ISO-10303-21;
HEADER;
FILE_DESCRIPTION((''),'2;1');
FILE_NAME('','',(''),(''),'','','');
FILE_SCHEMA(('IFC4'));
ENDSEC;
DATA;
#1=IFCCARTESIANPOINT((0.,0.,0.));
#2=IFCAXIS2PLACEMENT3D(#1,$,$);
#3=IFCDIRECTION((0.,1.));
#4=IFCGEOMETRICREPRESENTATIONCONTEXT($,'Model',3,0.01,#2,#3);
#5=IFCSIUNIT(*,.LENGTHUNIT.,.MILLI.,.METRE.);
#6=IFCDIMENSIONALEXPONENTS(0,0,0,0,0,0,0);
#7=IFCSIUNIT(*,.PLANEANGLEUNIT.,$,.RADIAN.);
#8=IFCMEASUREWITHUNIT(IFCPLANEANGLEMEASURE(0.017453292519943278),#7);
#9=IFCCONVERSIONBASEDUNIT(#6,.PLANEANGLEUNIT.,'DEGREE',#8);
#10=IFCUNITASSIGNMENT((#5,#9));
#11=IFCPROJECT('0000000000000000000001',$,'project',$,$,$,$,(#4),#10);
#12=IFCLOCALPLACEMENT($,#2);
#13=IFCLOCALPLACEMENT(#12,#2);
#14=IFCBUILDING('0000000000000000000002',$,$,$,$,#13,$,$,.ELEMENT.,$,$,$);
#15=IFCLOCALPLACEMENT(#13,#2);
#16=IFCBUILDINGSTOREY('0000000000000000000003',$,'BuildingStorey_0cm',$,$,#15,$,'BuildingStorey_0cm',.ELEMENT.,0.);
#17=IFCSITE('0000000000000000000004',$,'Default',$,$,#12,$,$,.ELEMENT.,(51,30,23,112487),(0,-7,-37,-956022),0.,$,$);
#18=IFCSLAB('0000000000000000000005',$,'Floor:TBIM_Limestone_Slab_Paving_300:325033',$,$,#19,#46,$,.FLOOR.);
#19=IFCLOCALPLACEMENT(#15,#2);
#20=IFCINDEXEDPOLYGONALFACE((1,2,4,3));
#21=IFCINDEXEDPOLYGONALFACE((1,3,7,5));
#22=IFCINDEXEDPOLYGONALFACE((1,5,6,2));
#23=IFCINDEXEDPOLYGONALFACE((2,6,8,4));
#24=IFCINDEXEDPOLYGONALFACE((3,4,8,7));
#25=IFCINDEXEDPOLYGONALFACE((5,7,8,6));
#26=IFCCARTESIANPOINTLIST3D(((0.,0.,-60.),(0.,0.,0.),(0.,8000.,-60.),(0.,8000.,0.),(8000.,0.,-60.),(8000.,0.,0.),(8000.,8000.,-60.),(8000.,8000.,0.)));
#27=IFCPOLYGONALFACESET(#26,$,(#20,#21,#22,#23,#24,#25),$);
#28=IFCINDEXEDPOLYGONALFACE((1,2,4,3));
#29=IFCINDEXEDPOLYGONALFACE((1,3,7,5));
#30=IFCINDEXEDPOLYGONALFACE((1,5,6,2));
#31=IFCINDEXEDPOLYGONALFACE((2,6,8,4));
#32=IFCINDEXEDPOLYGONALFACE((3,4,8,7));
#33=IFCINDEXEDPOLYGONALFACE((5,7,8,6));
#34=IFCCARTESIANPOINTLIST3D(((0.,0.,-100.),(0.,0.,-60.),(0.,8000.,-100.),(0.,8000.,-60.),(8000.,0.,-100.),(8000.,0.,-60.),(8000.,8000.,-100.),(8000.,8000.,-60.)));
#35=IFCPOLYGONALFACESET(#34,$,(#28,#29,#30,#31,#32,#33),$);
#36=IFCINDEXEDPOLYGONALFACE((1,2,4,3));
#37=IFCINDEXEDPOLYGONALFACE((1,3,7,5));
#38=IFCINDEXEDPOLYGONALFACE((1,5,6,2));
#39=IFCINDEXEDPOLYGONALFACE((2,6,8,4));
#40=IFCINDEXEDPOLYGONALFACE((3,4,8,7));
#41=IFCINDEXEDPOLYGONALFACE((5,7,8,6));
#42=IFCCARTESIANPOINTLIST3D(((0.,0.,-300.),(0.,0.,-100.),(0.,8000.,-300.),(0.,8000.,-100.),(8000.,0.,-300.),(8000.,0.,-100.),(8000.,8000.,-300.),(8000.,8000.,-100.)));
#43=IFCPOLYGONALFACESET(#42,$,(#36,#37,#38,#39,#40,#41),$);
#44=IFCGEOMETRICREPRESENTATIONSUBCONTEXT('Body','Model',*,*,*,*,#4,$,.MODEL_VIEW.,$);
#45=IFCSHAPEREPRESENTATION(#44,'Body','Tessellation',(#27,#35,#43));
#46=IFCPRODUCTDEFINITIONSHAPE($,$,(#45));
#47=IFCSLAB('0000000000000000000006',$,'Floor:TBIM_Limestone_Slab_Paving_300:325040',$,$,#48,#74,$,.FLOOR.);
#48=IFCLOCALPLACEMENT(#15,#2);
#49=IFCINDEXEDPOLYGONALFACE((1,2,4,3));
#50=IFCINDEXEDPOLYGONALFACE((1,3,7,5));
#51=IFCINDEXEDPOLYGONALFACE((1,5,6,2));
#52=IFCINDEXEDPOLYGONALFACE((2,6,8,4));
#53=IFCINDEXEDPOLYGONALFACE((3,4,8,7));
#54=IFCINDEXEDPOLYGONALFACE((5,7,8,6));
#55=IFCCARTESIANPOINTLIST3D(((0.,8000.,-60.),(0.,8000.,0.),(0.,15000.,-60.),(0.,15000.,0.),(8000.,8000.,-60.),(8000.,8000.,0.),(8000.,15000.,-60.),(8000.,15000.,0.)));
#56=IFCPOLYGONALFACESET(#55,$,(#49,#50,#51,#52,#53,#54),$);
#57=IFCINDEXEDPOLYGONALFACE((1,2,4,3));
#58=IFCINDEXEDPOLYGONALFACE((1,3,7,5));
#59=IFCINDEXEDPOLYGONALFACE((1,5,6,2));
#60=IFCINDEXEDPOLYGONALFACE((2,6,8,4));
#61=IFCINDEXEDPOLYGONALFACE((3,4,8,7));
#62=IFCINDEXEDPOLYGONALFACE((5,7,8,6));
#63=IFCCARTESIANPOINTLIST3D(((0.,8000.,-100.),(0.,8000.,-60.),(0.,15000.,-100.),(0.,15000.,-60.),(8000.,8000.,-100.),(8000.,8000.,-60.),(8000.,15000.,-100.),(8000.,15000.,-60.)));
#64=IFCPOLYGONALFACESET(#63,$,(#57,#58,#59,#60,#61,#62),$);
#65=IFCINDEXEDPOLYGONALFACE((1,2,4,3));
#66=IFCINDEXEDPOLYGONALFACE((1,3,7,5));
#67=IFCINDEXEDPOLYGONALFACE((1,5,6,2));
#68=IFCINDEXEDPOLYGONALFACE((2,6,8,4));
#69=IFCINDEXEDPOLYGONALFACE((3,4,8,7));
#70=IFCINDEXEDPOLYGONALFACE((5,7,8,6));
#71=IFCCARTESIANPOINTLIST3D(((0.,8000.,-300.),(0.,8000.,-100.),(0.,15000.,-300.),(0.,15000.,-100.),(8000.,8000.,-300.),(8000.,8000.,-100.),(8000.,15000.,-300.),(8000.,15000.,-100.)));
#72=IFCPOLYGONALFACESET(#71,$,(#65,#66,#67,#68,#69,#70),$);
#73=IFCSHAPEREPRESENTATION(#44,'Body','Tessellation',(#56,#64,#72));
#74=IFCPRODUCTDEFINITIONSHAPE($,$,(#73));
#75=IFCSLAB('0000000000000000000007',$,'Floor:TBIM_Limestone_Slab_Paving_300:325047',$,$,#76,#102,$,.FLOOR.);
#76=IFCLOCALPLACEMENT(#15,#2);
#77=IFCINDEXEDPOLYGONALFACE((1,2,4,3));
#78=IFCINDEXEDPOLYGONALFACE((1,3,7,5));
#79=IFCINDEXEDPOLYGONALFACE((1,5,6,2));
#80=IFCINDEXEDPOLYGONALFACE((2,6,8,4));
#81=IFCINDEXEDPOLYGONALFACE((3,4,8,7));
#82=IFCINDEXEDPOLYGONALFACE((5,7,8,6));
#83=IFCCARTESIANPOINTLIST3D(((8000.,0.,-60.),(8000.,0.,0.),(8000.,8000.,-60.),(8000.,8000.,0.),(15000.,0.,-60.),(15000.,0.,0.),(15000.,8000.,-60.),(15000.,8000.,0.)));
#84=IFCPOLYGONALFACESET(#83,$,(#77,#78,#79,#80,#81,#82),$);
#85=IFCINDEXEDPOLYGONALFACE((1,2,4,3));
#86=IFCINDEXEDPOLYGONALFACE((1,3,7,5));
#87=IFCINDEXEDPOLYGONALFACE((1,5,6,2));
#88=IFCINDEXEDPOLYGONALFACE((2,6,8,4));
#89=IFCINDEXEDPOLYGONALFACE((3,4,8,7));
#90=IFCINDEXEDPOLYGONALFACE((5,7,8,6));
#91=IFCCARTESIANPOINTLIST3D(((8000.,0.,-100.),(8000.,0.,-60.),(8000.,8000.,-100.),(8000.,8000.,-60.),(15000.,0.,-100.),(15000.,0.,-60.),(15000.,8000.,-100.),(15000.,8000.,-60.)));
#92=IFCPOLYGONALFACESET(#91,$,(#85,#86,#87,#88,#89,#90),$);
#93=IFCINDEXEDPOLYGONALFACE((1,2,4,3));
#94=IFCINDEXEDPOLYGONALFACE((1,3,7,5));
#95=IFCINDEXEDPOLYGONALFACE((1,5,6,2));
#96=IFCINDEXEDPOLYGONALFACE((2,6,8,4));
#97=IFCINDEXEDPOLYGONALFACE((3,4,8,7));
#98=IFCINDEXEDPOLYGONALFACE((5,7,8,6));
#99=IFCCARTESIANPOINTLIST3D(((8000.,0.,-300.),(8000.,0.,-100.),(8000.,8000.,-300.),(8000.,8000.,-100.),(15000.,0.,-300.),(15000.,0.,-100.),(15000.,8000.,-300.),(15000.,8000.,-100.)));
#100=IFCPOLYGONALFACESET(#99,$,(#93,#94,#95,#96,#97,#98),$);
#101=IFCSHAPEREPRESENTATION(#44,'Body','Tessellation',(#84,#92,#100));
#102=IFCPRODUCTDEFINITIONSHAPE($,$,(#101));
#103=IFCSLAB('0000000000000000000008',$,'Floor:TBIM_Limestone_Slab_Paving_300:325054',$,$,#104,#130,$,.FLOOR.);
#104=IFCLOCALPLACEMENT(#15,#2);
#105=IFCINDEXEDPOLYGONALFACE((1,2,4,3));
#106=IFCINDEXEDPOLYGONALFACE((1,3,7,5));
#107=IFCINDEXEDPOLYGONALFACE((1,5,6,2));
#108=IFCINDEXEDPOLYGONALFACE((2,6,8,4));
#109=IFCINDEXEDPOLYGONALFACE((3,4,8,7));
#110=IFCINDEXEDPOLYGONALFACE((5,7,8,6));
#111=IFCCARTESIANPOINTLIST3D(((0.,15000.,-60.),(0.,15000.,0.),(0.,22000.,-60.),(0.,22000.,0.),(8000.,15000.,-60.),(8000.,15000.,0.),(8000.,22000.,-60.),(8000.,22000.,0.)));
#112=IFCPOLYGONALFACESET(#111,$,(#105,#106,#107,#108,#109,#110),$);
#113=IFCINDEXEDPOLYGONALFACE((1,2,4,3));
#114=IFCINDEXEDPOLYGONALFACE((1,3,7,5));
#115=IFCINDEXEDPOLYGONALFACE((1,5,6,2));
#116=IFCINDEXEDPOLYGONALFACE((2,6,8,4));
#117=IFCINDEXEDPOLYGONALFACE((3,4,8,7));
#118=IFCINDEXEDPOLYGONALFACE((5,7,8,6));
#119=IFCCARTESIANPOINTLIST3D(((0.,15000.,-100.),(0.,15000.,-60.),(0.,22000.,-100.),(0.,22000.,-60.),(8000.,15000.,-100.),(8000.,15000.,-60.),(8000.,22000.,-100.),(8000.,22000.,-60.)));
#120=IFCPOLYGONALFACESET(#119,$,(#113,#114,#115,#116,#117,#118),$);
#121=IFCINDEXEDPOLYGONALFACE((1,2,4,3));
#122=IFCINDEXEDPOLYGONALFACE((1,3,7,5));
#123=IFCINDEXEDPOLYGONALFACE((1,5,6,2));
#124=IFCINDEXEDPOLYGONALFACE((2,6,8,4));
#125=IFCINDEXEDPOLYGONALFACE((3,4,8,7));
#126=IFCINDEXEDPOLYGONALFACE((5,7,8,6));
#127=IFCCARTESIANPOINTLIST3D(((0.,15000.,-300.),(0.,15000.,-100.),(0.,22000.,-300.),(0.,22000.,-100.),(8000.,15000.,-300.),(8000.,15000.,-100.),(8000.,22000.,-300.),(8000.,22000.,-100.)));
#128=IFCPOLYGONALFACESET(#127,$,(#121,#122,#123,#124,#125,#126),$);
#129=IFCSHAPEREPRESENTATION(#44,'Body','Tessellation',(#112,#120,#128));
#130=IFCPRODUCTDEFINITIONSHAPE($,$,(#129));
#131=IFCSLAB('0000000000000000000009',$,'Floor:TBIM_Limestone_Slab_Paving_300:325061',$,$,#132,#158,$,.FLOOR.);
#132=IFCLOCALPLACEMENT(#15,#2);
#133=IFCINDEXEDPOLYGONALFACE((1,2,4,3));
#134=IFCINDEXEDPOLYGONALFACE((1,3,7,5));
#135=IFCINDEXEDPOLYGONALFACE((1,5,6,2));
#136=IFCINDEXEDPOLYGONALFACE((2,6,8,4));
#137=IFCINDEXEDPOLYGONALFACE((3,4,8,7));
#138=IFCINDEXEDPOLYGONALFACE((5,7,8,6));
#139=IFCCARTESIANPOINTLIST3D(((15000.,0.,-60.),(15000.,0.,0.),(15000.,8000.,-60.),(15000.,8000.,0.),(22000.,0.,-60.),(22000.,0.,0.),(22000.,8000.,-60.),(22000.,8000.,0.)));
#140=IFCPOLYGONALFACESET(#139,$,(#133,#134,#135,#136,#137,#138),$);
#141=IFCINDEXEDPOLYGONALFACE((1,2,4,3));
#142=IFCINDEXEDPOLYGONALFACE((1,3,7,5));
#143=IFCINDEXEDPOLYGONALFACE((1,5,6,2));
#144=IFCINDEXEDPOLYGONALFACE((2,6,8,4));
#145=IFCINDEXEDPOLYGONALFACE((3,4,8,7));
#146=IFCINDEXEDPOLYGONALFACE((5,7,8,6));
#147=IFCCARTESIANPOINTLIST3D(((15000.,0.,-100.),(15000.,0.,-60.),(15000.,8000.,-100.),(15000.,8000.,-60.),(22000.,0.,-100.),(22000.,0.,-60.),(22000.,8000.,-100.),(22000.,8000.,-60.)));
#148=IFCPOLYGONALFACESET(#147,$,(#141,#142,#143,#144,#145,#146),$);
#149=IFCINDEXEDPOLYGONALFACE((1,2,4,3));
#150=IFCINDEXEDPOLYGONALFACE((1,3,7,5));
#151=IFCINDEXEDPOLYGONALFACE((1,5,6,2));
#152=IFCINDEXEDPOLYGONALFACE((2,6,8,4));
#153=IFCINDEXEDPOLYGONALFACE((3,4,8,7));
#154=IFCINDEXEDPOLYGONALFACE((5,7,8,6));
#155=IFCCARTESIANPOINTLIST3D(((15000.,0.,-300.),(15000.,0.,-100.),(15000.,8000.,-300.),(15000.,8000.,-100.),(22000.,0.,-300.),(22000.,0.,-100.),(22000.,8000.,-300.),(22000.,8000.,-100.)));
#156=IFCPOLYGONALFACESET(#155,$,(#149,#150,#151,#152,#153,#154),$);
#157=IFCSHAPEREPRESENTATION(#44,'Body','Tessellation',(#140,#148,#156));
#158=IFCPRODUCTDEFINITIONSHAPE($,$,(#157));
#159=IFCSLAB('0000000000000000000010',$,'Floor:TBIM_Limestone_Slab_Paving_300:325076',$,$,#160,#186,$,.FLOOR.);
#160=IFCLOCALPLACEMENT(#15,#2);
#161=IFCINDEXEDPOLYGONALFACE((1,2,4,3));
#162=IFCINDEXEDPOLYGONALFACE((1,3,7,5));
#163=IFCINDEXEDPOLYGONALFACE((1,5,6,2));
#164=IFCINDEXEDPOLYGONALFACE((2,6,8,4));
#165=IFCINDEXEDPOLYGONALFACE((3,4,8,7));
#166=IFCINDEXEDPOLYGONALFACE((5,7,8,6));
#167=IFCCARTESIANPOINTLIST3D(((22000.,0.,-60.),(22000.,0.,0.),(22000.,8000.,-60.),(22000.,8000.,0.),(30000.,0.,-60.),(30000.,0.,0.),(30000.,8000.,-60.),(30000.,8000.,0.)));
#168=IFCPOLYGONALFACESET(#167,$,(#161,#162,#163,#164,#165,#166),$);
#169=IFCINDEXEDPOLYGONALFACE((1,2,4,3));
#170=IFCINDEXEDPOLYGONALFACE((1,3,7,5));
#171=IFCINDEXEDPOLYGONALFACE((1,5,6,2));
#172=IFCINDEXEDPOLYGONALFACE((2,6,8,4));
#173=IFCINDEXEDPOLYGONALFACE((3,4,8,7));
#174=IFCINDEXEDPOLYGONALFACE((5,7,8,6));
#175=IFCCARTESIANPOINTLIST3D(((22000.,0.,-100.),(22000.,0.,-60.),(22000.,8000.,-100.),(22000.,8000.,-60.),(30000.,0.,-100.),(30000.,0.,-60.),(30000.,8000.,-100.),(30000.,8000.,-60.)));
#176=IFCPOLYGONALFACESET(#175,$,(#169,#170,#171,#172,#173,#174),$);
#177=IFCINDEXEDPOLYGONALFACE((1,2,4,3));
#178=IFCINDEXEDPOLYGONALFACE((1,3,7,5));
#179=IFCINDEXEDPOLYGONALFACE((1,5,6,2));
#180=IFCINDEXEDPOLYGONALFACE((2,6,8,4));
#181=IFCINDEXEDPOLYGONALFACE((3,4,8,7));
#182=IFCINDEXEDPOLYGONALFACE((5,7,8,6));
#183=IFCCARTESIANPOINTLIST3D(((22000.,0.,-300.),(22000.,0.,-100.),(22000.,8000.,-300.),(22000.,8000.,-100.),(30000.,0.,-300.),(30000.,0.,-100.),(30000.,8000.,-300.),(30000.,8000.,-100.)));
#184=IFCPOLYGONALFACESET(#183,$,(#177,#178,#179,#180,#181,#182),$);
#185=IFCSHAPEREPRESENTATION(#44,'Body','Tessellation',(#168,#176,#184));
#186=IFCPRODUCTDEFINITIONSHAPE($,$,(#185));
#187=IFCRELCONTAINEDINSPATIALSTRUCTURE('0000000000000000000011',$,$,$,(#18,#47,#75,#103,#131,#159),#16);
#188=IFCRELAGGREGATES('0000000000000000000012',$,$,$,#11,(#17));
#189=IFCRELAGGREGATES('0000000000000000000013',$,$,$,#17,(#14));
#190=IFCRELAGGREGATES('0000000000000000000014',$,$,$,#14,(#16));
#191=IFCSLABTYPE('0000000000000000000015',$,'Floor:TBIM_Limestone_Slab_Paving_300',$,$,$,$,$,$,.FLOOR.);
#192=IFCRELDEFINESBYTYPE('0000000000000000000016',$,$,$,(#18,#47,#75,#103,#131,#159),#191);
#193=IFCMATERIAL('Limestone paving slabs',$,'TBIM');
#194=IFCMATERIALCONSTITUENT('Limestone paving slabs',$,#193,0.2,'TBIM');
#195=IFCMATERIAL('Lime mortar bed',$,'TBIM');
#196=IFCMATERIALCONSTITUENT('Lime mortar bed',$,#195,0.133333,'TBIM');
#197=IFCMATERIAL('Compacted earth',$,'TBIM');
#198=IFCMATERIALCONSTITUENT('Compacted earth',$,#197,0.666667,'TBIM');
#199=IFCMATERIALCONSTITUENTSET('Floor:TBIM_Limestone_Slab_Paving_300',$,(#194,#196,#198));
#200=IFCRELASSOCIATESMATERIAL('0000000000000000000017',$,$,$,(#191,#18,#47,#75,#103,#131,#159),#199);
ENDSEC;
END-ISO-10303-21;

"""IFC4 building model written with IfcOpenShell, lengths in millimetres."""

from ifc_helpers import new_model, entity, si_unit, converted_unit, direction, frame, origin, place, context, subcontext, project, spatial, indexed_curve, outline, extrude, material, constituent, constituent_set, type_object, element, save


model = new_model("IFC4")

# Units and contexts
model_context = context("Model", 3, precision=0.01, world=origin(), true_north=direction((0.0, 1.0)))
body_context = subcontext(model_context, "Body", "Model", "MODEL_VIEW")
ifc_project = project(units=[si_unit("LENGTHUNIT", "METRE", prefix="MILLI"), converted_unit("PLANEANGLEUNIT", "DEGREE", entity("IfcPlaneAngleMeasure", 0.017453292519943278), si_unit("PLANEANGLEUNIT", "RADIAN"), dimensions=[0, 0, 0, 0, 0, 0, 0])], contexts=[model_context])

# Site, building, storey
site_placement = place(None, origin())
site = spatial("IfcSite", under=ifc_project, at=site_placement, Name="Default", CompositionType="ELEMENT", RefLatitude=(51, 30, 23, 112487), RefLongitude=(0, -7, -37, -956022), RefElevation=0.0)
building_placement = place(site_placement, origin())
building = spatial("IfcBuilding", under=site, at=building_placement, CompositionType="ELEMENT")
storey_placement = place(building_placement, origin())
storey = spatial("IfcBuildingStorey", under=building, at=storey_placement, Name="BuildingStorey_0cm", LongName="BuildingStorey_0cm", CompositionType="ELEMENT", Elevation=0.0)

# Slabs
ifc_material_1 = material(Name="Limestone paving slabs", Category="TBIM")
ifc_constituent_1 = constituent(ifc_material_1, Name="Limestone paving slabs", Category="TBIM", fraction=0.2)
ifc_material_2 = material(Name="Lime mortar bed", Category="TBIM")
ifc_constituent_2 = constituent(ifc_material_2, Name="Lime mortar bed", Category="TBIM", fraction=0.133333)
ifc_material_3 = material(Name="Compacted earth", Category="TBIM")
ifc_constituent_3 = constituent(ifc_material_3, Name="Compacted earth", Category="TBIM", fraction=0.666667)
ifc_constituent_set_1 = constituent_set(constituents=[ifc_constituent_1, ifc_constituent_2, ifc_constituent_3], Name="Floor:TBIM_Limestone_Slab_Paving_300")
slab_type = type_object("IfcSlabType", Name="Floor:TBIM_Limestone_Slab_Paving_300", PredefinedType="FLOOR", material=ifc_constituent_set_1)
slab_1_placement = place(storey_placement, origin())
element("IfcSlab", 1, at=slab_1_placement, inside=storey, type_object=slab_type, material=ifc_constituent_set_1, Name="Floor:TBIM_Limestone_Slab_Paving_300:325033", PredefinedType="FLOOR", context=body_context, shape_type="SweptSolid", body=[
    extrude(outline(indexed_curve([(-4000.0, -4000.0), (4000.0, -4000.0), (4000.0, 4000.0), (-4000.0, 4000.0), (-4000.0, -4000.0)], self_intersect=False)), frame((4000.0, 4000.0, -60.0), z_axis=(0.0, 0.0, 1.0), x_axis=(-1.0, 0.0, 0.0)), (0.0, 0.0, 1.0), 60.0),
    extrude(outline(indexed_curve([(-4000.0, -4000.0), (4000.0, -4000.0), (4000.0, 4000.0), (-4000.0, 4000.0), (-4000.0, -4000.0)], self_intersect=False)), frame((4000.0, 4000.0, -100.0), z_axis=(0.0, 0.0, 1.0), x_axis=(-1.0, 0.0, 0.0)), (0.0, 0.0, 1.0), 40.0),
    extrude(outline(indexed_curve([(-4000.0, -4000.0), (4000.0, -4000.0), (4000.0, 4000.0), (-4000.0, 4000.0), (-4000.0, -4000.0)], self_intersect=False)), frame((4000.0, 4000.0, -300.0), z_axis=(0.0, 0.0, 1.0), x_axis=(-1.0, 0.0, 0.0)), (0.0, 0.0, 1.0), 200.0),
])
slab_2_placement = place(storey_placement, origin())
element("IfcSlab", 2, at=slab_2_placement, inside=storey, type_object=slab_type, material=ifc_constituent_set_1, Name="Floor:TBIM_Limestone_Slab_Paving_300:325040", PredefinedType="FLOOR", context=body_context, shape_type="SweptSolid", body=[
    extrude(outline(indexed_curve([(-4000.0, -3500.0), (4000.0, -3500.0), (4000.0, 3500.0), (-4000.0, 3500.0), (-4000.0, -3500.0)], self_intersect=False)), frame((4000.0, 11500.0, -60.0), z_axis=(0.0, 0.0, 1.0), x_axis=(-1.0, 0.0, 0.0)), (0.0, 0.0, 1.0), 60.0),
    extrude(outline(indexed_curve([(-4000.0, -3500.0), (4000.0, -3500.0), (4000.0, 3500.0), (-4000.0, 3500.0), (-4000.0, -3500.0)], self_intersect=False)), frame((4000.0, 11500.0, -100.0), z_axis=(0.0, 0.0, 1.0), x_axis=(-1.0, 0.0, 0.0)), (0.0, 0.0, 1.0), 40.0),
    extrude(outline(indexed_curve([(-4000.0, -3500.0), (4000.0, -3500.0), (4000.0, 3500.0), (-4000.0, 3500.0), (-4000.0, -3500.0)], self_intersect=False)), frame((4000.0, 11500.0, -300.0), z_axis=(0.0, 0.0, 1.0), x_axis=(-1.0, 0.0, 0.0)), (0.0, 0.0, 1.0), 200.0),
])
slab_3_placement = place(storey_placement, origin())
element("IfcSlab", 3, at=slab_3_placement, inside=storey, type_object=slab_type, material=ifc_constituent_set_1, Name="Floor:TBIM_Limestone_Slab_Paving_300:325047", PredefinedType="FLOOR", context=body_context, shape_type="SweptSolid", body=[
    extrude(outline(indexed_curve([(-3500.0, -4000.0), (3500.0, -4000.0), (3500.0, 4000.0), (-3500.0, 4000.0), (-3500.0, -4000.0)], self_intersect=False)), frame((11500.0, 4000.0, -60.0), z_axis=(0.0, 0.0, 1.0), x_axis=(-1.0, 0.0, 0.0)), (0.0, 0.0, 1.0), 60.0),
    extrude(outline(indexed_curve([(-3500.0, -4000.0), (3500.0, -4000.0), (3500.0, 4000.0), (-3500.0, 4000.0), (-3500.0, -4000.0)], self_intersect=False)), frame((11500.0, 4000.0, -100.0), z_axis=(0.0, 0.0, 1.0), x_axis=(-1.0, 0.0, 0.0)), (0.0, 0.0, 1.0), 40.0),
    extrude(outline(indexed_curve([(-3500.0, -4000.0), (3500.0, -4000.0), (3500.0, 4000.0), (-3500.0, 4000.0), (-3500.0, -4000.0)], self_intersect=False)), frame((11500.0, 4000.0, -300.0), z_axis=(0.0, 0.0, 1.0), x_axis=(-1.0, 0.0, 0.0)), (0.0, 0.0, 1.0), 200.0),
])
slab_4_placement = place(storey_placement, origin())
element("IfcSlab", 4, at=slab_4_placement, inside=storey, type_object=slab_type, material=ifc_constituent_set_1, Name="Floor:TBIM_Limestone_Slab_Paving_300:325054", PredefinedType="FLOOR", context=body_context, shape_type="SweptSolid", body=[
    extrude(outline(indexed_curve([(-3500.0, -4000.0), (3500.0, -4000.0), (3500.0, 4000.0), (-3500.0, 4000.0), (-3500.0, -4000.0)], self_intersect=False)), frame((4000.0, 18500.0, -60.0), z_axis=(0.0, 0.0, 1.0), x_axis=(0.0, 1.0, 0.0)), (0.0, 0.0, 1.0), 60.0),
    extrude(outline(indexed_curve([(-3500.0, -4000.0), (3500.0, -4000.0), (3500.0, 4000.0), (-3500.0, 4000.0), (-3500.0, -4000.0)], self_intersect=False)), frame((4000.0, 18500.0, -100.0), z_axis=(0.0, 0.0, 1.0), x_axis=(0.0, 1.0, 0.0)), (0.0, 0.0, 1.0), 40.0),
    extrude(outline(indexed_curve([(-3500.0, -4000.0), (3500.0, -4000.0), (3500.0, 4000.0), (-3500.0, 4000.0), (-3500.0, -4000.0)], self_intersect=False)), frame((4000.0, 18500.0, -300.0), z_axis=(0.0, 0.0, 1.0), x_axis=(0.0, 1.0, 0.0)), (0.0, 0.0, 1.0), 200.0),
])
slab_5_placement = place(storey_placement, origin())
element("IfcSlab", 5, at=slab_5_placement, inside=storey, type_object=slab_type, material=ifc_constituent_set_1, Name="Floor:TBIM_Limestone_Slab_Paving_300:325061", PredefinedType="FLOOR", context=body_context, shape_type="SweptSolid", body=[
    extrude(outline(indexed_curve([(-3500.0, -4000.0), (3500.0, -4000.0), (3500.0, 4000.0), (-3500.0, 4000.0), (-3500.0, -4000.0)], self_intersect=False)), frame((18500.0, 4000.0, -60.0), z_axis=(0.0, 0.0, 1.0), x_axis=(-1.0, 0.0, 0.0)), (0.0, 0.0, 1.0), 60.0),
    extrude(outline(indexed_curve([(-3500.0, -4000.0), (3500.0, -4000.0), (3500.0, 4000.0), (-3500.0, 4000.0), (-3500.0, -4000.0)], self_intersect=False)), frame((18500.0, 4000.0, -100.0), z_axis=(0.0, 0.0, 1.0), x_axis=(-1.0, 0.0, 0.0)), (0.0, 0.0, 1.0), 40.0),
    extrude(outline(indexed_curve([(-3500.0, -4000.0), (3500.0, -4000.0), (3500.0, 4000.0), (-3500.0, 4000.0), (-3500.0, -4000.0)], self_intersect=False)), frame((18500.0, 4000.0, -300.0), z_axis=(0.0, 0.0, 1.0), x_axis=(-1.0, 0.0, 0.0)), (0.0, 0.0, 1.0), 200.0),
])
slab_6_placement = place(storey_placement, origin())
element("IfcSlab", 6, at=slab_6_placement, inside=storey, type_object=slab_type, material=ifc_constituent_set_1, Name="Floor:TBIM_Limestone_Slab_Paving_300:325076", PredefinedType="FLOOR", context=body_context, shape_type="SweptSolid", body=[
    extrude(outline(indexed_curve([(-4000.0, -4000.0), (4000.0, -4000.0), (4000.0, 4000.0), (-4000.0, 4000.0), (-4000.0, -4000.0)], self_intersect=False)), frame((26000.0, 4000.0, -60.0), z_axis=(0.0, 0.0, 1.0), x_axis=(-1.0, 0.0, 0.0)), (0.0, 0.0, 1.0), 60.0),
    extrude(outline(indexed_curve([(-4000.0, -4000.0), (4000.0, -4000.0), (4000.0, 4000.0), (-4000.0, 4000.0), (-4000.0, -4000.0)], self_intersect=False)), frame((26000.0, 4000.0, -100.0), z_axis=(0.0, 0.0, 1.0), x_axis=(-1.0, 0.0, 0.0)), (0.0, 0.0, 1.0), 40.0),
    extrude(outline(indexed_curve([(-4000.0, -4000.0), (4000.0, -4000.0), (4000.0, 4000.0), (-4000.0, 4000.0), (-4000.0, -4000.0)], self_intersect=False)), frame((26000.0, 4000.0, -300.0), z_axis=(0.0, 0.0, 1.0), x_axis=(-1.0, 0.0, 0.0)), (0.0, 0.0, 1.0), 200.0),
])

save(model, "model.ifc")
